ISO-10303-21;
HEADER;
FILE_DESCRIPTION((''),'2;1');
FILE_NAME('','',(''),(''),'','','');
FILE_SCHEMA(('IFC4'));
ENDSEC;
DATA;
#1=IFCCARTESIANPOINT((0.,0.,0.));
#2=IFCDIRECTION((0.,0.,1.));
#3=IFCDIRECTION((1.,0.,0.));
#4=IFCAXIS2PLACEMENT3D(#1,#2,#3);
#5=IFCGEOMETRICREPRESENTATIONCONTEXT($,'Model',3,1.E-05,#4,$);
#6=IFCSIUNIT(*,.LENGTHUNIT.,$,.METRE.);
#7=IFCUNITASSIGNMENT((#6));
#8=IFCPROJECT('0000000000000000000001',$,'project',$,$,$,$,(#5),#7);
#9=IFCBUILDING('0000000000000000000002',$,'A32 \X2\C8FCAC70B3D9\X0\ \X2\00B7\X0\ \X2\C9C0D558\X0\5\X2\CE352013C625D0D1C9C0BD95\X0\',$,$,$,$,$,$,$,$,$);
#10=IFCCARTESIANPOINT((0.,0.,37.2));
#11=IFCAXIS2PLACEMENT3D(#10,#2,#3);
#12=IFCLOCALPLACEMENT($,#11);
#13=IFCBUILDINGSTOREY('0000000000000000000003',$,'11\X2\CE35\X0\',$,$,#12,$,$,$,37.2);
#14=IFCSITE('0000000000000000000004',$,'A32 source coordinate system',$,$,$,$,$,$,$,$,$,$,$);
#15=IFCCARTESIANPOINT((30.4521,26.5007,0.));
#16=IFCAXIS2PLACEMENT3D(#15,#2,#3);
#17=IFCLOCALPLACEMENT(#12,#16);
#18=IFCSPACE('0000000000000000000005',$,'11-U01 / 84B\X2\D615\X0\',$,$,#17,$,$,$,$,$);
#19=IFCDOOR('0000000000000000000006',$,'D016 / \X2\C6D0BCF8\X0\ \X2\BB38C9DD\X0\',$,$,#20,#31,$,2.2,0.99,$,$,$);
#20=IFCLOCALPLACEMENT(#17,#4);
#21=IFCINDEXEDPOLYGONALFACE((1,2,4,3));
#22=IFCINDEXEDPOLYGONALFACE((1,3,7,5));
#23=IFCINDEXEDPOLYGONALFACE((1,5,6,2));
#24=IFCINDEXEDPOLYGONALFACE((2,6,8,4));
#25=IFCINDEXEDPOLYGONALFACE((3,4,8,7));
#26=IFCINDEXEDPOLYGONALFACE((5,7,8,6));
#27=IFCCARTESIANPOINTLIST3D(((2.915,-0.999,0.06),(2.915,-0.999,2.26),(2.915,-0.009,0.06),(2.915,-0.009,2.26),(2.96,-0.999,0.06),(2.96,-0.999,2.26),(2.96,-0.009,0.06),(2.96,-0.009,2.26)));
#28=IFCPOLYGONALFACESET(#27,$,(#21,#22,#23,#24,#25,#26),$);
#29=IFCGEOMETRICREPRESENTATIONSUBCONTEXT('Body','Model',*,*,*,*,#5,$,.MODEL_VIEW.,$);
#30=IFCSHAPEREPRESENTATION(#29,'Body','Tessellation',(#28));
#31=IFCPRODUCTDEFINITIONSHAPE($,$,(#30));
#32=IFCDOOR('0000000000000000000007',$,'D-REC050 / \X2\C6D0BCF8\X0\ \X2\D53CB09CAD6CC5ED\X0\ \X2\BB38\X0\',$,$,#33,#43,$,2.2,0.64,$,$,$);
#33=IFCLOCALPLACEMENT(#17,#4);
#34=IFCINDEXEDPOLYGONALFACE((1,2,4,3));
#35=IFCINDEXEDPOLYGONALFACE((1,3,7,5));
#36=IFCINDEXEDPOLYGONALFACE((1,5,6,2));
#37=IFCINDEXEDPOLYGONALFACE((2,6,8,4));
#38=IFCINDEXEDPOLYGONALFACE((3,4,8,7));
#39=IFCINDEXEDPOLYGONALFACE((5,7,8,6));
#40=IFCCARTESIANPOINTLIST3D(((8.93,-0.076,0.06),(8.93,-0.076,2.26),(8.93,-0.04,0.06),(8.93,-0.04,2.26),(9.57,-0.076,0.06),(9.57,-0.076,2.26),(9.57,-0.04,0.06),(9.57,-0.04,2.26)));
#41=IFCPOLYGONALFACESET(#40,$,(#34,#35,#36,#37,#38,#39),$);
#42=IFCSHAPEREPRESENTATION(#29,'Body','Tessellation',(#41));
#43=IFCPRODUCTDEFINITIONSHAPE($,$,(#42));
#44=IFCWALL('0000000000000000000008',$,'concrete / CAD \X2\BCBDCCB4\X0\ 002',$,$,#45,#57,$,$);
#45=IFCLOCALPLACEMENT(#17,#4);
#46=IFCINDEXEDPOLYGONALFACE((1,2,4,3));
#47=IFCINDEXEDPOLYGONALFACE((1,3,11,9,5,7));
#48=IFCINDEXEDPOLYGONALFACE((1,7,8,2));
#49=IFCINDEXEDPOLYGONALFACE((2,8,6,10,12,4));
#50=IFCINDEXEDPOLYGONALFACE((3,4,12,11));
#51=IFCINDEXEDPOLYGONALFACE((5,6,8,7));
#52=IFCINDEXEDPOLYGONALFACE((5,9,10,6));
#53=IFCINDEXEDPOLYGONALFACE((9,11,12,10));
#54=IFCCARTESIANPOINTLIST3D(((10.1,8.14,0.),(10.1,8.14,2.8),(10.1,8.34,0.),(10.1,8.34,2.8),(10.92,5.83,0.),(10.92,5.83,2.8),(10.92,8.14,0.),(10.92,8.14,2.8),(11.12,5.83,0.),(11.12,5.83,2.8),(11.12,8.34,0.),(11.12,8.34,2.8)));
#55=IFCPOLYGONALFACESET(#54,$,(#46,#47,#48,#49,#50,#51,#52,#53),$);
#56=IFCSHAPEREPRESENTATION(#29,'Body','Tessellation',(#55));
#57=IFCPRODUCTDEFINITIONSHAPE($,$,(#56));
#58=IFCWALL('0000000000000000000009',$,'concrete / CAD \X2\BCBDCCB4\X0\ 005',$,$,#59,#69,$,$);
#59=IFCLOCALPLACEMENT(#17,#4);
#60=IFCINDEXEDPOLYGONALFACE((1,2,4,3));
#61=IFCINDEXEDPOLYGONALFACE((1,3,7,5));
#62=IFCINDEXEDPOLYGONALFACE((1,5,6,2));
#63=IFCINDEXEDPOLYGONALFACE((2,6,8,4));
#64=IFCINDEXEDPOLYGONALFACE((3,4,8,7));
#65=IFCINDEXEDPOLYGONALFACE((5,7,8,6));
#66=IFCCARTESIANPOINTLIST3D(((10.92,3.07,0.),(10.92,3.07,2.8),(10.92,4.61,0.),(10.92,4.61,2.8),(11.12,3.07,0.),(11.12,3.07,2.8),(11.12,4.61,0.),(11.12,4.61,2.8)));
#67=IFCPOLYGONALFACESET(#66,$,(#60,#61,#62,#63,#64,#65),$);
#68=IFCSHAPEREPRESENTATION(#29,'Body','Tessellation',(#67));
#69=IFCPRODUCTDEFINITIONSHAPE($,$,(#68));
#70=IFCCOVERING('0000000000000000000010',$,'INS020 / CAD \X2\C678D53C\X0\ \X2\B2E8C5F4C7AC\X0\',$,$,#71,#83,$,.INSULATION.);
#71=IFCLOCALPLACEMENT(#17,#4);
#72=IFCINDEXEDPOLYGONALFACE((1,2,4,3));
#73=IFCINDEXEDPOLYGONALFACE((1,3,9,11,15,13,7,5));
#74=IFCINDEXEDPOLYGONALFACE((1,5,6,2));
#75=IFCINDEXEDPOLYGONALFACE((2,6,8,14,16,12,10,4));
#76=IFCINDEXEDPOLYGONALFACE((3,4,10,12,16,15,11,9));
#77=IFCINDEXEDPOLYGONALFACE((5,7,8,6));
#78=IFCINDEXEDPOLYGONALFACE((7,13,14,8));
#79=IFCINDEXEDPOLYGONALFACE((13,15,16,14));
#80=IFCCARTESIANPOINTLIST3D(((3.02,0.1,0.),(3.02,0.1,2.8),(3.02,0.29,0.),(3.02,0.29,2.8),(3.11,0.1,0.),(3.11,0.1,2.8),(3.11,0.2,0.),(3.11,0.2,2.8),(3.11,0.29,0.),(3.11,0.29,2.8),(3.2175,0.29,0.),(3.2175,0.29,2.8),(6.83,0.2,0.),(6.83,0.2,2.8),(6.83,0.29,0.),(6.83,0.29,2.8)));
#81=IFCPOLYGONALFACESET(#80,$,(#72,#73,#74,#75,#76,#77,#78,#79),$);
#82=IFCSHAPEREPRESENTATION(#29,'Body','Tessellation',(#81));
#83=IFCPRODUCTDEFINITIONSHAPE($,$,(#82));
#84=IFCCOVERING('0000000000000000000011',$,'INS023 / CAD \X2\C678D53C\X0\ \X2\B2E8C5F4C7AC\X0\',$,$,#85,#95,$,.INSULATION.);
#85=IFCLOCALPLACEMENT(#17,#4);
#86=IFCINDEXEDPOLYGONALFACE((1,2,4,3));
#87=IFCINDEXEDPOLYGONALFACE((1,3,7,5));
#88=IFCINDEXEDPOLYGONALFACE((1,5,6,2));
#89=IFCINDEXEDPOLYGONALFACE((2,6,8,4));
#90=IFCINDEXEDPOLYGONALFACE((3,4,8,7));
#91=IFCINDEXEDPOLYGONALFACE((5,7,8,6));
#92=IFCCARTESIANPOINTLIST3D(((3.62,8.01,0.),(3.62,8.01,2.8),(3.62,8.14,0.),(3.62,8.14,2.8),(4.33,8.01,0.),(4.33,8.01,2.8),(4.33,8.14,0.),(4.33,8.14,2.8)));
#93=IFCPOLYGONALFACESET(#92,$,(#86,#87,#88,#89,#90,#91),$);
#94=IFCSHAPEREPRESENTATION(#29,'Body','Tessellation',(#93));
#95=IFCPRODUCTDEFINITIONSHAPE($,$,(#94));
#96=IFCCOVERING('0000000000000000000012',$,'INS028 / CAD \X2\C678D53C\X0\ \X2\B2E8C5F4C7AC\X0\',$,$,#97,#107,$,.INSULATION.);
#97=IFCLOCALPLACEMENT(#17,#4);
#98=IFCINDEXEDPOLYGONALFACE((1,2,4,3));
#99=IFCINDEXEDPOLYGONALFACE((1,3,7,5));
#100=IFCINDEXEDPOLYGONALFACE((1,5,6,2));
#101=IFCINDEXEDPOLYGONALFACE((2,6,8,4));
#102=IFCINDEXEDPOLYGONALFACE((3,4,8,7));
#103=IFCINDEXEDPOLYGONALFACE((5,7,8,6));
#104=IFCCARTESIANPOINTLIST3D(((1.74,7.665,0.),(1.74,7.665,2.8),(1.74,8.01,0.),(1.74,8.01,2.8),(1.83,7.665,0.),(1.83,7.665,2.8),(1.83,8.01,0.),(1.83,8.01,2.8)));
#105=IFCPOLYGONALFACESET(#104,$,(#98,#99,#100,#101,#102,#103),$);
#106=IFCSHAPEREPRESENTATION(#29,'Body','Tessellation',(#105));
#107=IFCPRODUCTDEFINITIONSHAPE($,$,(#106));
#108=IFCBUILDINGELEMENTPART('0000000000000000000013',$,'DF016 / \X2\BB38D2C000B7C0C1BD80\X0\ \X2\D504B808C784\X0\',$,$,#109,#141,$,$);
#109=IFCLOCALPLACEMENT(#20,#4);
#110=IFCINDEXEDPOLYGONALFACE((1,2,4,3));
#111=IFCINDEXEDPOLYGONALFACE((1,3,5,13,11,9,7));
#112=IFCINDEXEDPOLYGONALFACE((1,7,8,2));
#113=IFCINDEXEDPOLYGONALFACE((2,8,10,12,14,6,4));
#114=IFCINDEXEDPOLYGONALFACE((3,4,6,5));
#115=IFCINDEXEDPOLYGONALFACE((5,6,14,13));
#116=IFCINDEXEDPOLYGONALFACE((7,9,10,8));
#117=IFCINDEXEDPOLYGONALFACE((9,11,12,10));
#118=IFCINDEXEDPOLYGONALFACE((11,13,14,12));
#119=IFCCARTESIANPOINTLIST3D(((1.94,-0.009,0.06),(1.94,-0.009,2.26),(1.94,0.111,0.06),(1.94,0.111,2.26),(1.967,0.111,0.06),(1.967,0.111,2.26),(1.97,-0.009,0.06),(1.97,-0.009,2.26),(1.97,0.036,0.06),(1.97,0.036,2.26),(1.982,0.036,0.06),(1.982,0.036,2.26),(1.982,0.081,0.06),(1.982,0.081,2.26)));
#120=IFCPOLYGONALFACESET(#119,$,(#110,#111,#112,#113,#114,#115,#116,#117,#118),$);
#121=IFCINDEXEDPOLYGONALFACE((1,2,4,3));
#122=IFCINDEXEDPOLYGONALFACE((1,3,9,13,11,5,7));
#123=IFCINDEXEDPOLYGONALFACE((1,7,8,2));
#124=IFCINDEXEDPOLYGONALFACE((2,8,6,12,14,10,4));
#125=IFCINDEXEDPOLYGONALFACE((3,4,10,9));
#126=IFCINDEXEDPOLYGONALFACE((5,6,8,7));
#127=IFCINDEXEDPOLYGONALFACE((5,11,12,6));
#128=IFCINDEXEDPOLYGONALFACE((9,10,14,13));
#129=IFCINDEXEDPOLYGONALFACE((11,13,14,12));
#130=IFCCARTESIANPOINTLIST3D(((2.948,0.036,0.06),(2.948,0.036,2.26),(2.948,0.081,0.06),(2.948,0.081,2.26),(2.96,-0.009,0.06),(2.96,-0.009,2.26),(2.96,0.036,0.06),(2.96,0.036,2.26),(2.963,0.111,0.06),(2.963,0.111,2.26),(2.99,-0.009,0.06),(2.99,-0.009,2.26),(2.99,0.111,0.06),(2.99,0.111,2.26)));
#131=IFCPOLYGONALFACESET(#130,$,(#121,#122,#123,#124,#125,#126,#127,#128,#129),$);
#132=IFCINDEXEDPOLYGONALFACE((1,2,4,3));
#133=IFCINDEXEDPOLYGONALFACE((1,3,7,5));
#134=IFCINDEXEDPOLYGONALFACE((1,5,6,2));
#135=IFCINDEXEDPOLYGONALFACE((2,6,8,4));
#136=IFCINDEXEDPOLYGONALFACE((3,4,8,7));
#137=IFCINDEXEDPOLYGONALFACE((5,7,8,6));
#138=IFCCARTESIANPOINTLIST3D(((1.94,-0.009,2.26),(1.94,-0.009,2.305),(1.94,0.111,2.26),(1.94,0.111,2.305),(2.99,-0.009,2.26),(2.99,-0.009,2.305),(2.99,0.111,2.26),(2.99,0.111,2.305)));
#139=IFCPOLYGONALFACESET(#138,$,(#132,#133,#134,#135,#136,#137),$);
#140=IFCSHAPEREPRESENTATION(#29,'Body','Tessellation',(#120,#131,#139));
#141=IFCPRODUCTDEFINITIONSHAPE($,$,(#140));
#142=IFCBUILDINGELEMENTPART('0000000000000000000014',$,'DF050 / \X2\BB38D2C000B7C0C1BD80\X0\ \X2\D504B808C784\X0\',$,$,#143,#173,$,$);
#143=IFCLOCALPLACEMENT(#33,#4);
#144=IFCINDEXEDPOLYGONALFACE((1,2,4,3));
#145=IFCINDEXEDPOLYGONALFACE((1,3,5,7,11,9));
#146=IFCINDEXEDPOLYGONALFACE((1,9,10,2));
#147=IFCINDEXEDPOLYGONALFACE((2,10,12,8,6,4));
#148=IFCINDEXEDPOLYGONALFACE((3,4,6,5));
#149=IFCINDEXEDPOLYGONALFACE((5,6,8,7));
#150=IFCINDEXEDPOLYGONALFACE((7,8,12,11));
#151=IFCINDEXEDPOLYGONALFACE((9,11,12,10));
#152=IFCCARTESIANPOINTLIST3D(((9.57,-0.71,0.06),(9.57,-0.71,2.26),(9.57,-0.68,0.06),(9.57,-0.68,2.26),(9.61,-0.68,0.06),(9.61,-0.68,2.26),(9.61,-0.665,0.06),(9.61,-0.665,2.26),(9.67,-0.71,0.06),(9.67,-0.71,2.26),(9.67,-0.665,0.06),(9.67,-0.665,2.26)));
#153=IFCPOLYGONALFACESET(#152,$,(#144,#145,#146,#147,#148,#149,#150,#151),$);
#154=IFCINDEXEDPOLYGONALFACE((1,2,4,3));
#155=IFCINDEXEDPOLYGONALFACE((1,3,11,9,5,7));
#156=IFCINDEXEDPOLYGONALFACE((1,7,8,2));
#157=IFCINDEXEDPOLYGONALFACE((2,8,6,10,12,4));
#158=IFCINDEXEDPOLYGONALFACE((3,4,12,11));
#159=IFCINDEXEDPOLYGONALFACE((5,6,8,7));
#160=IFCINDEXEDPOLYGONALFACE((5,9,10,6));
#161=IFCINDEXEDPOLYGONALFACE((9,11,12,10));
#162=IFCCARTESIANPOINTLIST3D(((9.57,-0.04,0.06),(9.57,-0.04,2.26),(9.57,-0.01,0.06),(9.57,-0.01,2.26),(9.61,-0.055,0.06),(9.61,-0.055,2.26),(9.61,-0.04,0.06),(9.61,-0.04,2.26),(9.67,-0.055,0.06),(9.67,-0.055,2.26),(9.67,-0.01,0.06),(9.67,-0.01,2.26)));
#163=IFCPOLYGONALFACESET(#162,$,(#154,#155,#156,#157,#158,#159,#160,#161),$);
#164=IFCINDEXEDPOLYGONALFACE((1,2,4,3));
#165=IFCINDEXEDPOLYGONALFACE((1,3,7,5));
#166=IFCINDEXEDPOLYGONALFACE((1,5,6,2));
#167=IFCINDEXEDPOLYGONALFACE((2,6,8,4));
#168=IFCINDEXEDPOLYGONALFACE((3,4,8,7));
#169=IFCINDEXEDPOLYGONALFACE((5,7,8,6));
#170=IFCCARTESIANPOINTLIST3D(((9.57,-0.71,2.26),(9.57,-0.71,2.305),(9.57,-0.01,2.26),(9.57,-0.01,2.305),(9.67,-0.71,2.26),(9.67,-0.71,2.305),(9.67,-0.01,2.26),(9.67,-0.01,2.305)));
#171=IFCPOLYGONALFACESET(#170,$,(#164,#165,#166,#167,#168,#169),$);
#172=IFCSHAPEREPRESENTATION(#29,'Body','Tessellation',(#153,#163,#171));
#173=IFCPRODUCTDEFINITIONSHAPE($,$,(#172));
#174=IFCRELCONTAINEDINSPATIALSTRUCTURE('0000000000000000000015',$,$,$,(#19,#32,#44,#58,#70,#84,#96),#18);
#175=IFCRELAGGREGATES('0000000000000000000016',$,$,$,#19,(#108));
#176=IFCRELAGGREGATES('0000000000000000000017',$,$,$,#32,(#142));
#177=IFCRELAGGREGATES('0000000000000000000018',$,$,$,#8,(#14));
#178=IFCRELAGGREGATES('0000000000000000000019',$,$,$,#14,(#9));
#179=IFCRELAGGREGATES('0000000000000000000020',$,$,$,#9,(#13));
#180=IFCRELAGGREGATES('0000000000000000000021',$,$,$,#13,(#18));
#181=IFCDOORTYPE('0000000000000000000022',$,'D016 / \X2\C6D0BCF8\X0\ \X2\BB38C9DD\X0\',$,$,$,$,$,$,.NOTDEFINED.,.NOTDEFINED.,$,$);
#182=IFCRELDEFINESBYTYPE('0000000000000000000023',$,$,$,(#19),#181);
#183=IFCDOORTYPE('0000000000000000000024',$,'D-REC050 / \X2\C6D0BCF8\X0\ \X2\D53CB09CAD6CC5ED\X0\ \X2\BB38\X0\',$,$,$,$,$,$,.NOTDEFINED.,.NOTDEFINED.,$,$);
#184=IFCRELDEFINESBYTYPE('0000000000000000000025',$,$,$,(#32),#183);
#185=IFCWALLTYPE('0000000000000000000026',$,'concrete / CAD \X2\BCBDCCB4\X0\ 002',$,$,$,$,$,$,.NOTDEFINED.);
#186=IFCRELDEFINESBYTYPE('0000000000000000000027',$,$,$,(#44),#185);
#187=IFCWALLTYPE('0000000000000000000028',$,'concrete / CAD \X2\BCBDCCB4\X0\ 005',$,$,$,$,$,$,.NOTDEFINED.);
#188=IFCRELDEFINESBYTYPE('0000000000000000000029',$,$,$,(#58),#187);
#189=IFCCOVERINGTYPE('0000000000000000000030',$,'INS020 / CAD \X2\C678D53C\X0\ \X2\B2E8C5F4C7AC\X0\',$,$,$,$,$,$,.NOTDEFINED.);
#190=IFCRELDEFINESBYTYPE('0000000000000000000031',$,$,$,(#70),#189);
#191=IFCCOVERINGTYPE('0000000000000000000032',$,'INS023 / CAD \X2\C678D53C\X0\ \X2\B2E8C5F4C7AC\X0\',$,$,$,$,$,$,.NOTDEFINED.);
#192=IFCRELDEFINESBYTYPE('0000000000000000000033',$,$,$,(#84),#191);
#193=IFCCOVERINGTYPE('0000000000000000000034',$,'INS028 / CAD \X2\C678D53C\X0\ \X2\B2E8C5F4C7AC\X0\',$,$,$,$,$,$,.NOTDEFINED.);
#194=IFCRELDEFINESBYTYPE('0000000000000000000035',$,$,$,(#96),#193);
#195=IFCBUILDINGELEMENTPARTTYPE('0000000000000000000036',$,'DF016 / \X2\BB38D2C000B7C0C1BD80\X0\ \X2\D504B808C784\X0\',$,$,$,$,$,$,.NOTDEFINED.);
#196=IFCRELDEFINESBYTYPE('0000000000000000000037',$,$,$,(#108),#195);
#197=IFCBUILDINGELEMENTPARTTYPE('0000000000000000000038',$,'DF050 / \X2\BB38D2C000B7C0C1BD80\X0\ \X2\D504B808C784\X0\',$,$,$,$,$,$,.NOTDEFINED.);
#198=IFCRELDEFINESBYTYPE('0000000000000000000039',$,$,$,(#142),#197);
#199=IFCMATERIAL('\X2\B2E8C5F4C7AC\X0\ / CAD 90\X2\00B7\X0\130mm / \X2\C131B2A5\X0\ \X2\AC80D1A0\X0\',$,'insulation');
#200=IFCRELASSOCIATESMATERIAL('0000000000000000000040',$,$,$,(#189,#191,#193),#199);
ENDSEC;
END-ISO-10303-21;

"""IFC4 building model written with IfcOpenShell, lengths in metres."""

from ifc_helpers import new_model, si_unit, frame, origin, origin_with_axes, place, context, subcontext, project, spatial, polyline, outline, extrude, source, transform, mapped, material, type_object, type_shapes, element, aggregate, save


model = new_model("IFC4")

# Units and contexts
model_context = context("Model", 3, precision=1e-05, world=origin_with_axes())
body_context = subcontext(model_context, "Body", "Model", "MODEL_VIEW")
ifc_project = project(units=[si_unit("LENGTHUNIT", "METRE")], contexts=[model_context])

# Site, building, storey, space
storey_placement = place(None, frame((0.0, 0.0, 37.2), z_axis=(0.0, 0.0, 1.0), x_axis=(1.0, 0.0, 0.0)))
space_placement = place(storey_placement, frame((30.4521, 26.5007, 0.0), z_axis=(0.0, 0.0, 1.0), x_axis=(1.0, 0.0, 0.0)))
site = spatial("IfcSite", under=ifc_project, Name="A32 source coordinate system")
building = spatial("IfcBuilding", under=site, Name="A32 주거동 · 지하5층–옥탑지붕")
storey = spatial("IfcBuildingStorey", under=building, at=storey_placement, Name="11층", Elevation=37.2)
space = spatial("IfcSpace", under=storey, at=space_placement, Name="11-U01 / 84B형")

# Doors
door_type_1 = type_object("IfcDoorType", Name="D016 / 원본 문짝", OperationType="NOTDEFINED", PredefinedType="NOTDEFINED")
shared_shape_1 = source(origin(), body_context, "Body", "SweptSolid", [
    extrude(outline(polyline([(2.96, -0.009), (2.96, -0.999), (2.915, -0.999), (2.915, -0.009), (2.96, -0.009)])), frame((0.0, 0.0, 0.06)), (0.0, 0.0, 1.0), 2.2),
])
type_shapes(door_type_1, [shared_shape_1])
door_1_placement = place(space_placement, origin_with_axes())
door_1 = element("IfcDoor", 1, at=door_1_placement, inside=space, type_object=door_type_1, Name="D016 / 원본 문짝", OverallHeight=2.2, OverallWidth=0.99, context=body_context, shape_type="MappedRepresentation", body=[
    mapped(shared_shape_1, transform((0.0, 0.0, 0.0), scale=1.0)),
])
door_type_2 = type_object("IfcDoorType", Name="D-REC050 / 원본 피난구역 문", OperationType="NOTDEFINED", PredefinedType="NOTDEFINED")
shared_shape_2 = source(origin(), body_context, "Body", "SweptSolid", [
    extrude(outline(polyline([(9.57, -0.04), (9.57, -0.076), (8.93, -0.076), (8.93, -0.04), (9.57, -0.04)])), frame((0.0, 0.0, 0.06)), (0.0, 0.0, 1.0), 2.2),
])
type_shapes(door_type_2, [shared_shape_2])
door_2_placement = place(space_placement, origin_with_axes())
door_2 = element("IfcDoor", 2, at=door_2_placement, inside=space, type_object=door_type_2, Name="D-REC050 / 원본 피난구역 문", OverallHeight=2.2, OverallWidth=0.64, context=body_context, shape_type="MappedRepresentation", body=[
    mapped(shared_shape_2, transform((0.0, 0.0, 0.0), scale=1.0)),
])

# Walls
wall_type_1 = type_object("IfcWallType", Name="concrete / CAD 벽체 002", PredefinedType="NOTDEFINED")
shared_shape_3 = source(origin(), body_context, "Body", "SweptSolid", [
    extrude(outline(polyline([(11.12, 5.83), (10.92, 5.83), (10.92, 8.14), (10.1, 8.14), (10.1, 8.34), (11.12, 8.34), (11.12, 5.83)])), origin(), (0.0, 0.0, 1.0), 2.8),
])
type_shapes(wall_type_1, [shared_shape_3])
wall_1_placement = place(space_placement, origin_with_axes())
element("IfcWall", 3, at=wall_1_placement, inside=space, type_object=wall_type_1, Name="concrete / CAD 벽체 002", context=body_context, shape_type="MappedRepresentation", body=[
    mapped(shared_shape_3, transform((0.0, 0.0, 0.0), scale=1.0)),
])
wall_type_2 = type_object("IfcWallType", Name="concrete / CAD 벽체 005", PredefinedType="NOTDEFINED")
shared_shape_4 = source(origin(), body_context, "Body", "SweptSolid", [
    extrude(outline(polyline([(11.12, 3.07), (10.92, 3.07), (10.92, 4.61), (11.12, 4.61), (11.12, 3.07)])), origin(), (0.0, 0.0, 1.0), 2.8),
])
type_shapes(wall_type_2, [shared_shape_4])
wall_2_placement = place(space_placement, origin_with_axes())
element("IfcWall", 4, at=wall_2_placement, inside=space, type_object=wall_type_2, Name="concrete / CAD 벽체 005", context=body_context, shape_type="MappedRepresentation", body=[
    mapped(shared_shape_4, transform((0.0, 0.0, 0.0), scale=1.0)),
])

# Coverings
ifc_material = material(Name="단열재 / CAD 90·130mm / 성능 검토", Category="insulation")
covering_type_1 = type_object("IfcCoveringType", Name="INS020 / CAD 외피 단열재", PredefinedType="NOTDEFINED", material=ifc_material)
shared_shape_5 = source(origin(), body_context, "Body", "SweptSolid", [
    extrude(outline(polyline([(3.11, 0.2), (3.11, 0.1), (3.02, 0.1), (3.02, 0.29), (3.11, 0.29), (3.2175, 0.29), (6.83, 0.29), (6.83, 0.2), (3.11, 0.2)])), origin(), (0.0, 0.0, 1.0), 2.8),
])
type_shapes(covering_type_1, [shared_shape_5])
covering_1_placement = place(space_placement, origin_with_axes())
element("IfcCovering", 5, at=covering_1_placement, inside=space, type_object=covering_type_1, Name="INS020 / CAD 외피 단열재", PredefinedType="INSULATION", context=body_context, shape_type="MappedRepresentation", body=[
    mapped(shared_shape_5, transform((0.0, 0.0, 0.0), scale=1.0)),
])
covering_type_2 = type_object("IfcCoveringType", Name="INS023 / CAD 외피 단열재", PredefinedType="NOTDEFINED", material=ifc_material)
shared_shape_6 = source(origin(), body_context, "Body", "SweptSolid", [
    extrude(outline(polyline([(4.33, 8.01), (3.62, 8.01), (3.62, 8.14), (4.33, 8.14), (4.33, 8.01)])), origin(), (0.0, 0.0, 1.0), 2.8),
])
type_shapes(covering_type_2, [shared_shape_6])
covering_2_placement = place(space_placement, origin_with_axes())
element("IfcCovering", 6, at=covering_2_placement, inside=space, type_object=covering_type_2, Name="INS023 / CAD 외피 단열재", PredefinedType="INSULATION", context=body_context, shape_type="MappedRepresentation", body=[
    mapped(shared_shape_6, transform((0.0, 0.0, 0.0), scale=1.0)),
])
covering_type_3 = type_object("IfcCoveringType", Name="INS028 / CAD 외피 단열재", PredefinedType="NOTDEFINED", material=ifc_material)
shared_shape_7 = source(origin(), body_context, "Body", "SweptSolid", [
    extrude(outline(polyline([(1.74, 8.01), (1.83, 8.01), (1.83, 7.665), (1.74, 7.665), (1.74, 8.01)])), origin(), (0.0, 0.0, 1.0), 2.8),
])
type_shapes(covering_type_3, [shared_shape_7])
covering_3_placement = place(space_placement, origin_with_axes())
element("IfcCovering", 7, at=covering_3_placement, inside=space, type_object=covering_type_3, Name="INS028 / CAD 외피 단열재", PredefinedType="INSULATION", context=body_context, shape_type="MappedRepresentation", body=[
    mapped(shared_shape_7, transform((0.0, 0.0, 0.0), scale=1.0)),
])

# Building element parts
building_element_part_type_1 = type_object("IfcBuildingElementPartType", Name="DF016 / 문틀·상부 프레임", PredefinedType="NOTDEFINED")
shared_shape_8 = source(origin(), body_context, "Body", "SweptSolid", [
    extrude(outline(polyline([(1.94, 0.111), (1.967, 0.111), (1.982, 0.081), (1.982, 0.036), (1.97, 0.036), (1.97, -0.009), (1.94, -0.009), (1.94, 0.111)])), frame((0.0, 0.0, 0.06)), (0.0, 0.0, 1.0), 2.2),
    extrude(outline(polyline([(2.96, -0.009), (2.96, 0.036), (2.948, 0.036), (2.948, 0.081), (2.963, 0.111), (2.99, 0.111), (2.99, -0.009), (2.96, -0.009)])), frame((0.0, 0.0, 0.06)), (0.0, 0.0, 1.0), 2.2),
    extrude(outline(polyline([(1.94, -0.009), (1.94, 0.111), (2.99, 0.111), (2.99, -0.009), (1.94, -0.009)])), frame((0.0, 0.0, 2.26)), (0.0, 0.0, 1.0), 0.045),
])
type_shapes(building_element_part_type_1, [shared_shape_8])
building_element_part_1_placement = place(door_1_placement, origin_with_axes())
building_element_part_1 = element("IfcBuildingElementPart", 8, at=building_element_part_1_placement, type_object=building_element_part_type_1, Name="DF016 / 문틀·상부 프레임", context=body_context, shape_type="MappedRepresentation", body=[
    mapped(shared_shape_8, transform((0.0, 0.0, 0.0), scale=1.0)),
])
aggregate(door_1, [building_element_part_1])
building_element_part_type_2 = type_object("IfcBuildingElementPartType", Name="DF050 / 문틀·상부 프레임", PredefinedType="NOTDEFINED")
shared_shape_9 = source(origin(), body_context, "Body", "SweptSolid", [
    extrude(outline(polyline([(9.57, -0.68), (9.61, -0.68), (9.61, -0.665), (9.67, -0.665), (9.67, -0.71), (9.57, -0.71), (9.57, -0.68)])), frame((0.0, 0.0, 0.06)), (0.0, 0.0, 1.0), 2.2),
    extrude(outline(polyline([(9.67, -0.01), (9.67, -0.055), (9.61, -0.055), (9.61, -0.04), (9.57, -0.04), (9.57, -0.01), (9.67, -0.01)])), frame((0.0, 0.0, 0.06)), (0.0, 0.0, 1.0), 2.2),
    extrude(outline(polyline([(9.57, -0.71), (9.57, -0.01), (9.67, -0.01), (9.67, -0.71), (9.57, -0.71)])), frame((0.0, 0.0, 2.26)), (0.0, 0.0, 1.0), 0.045),
])
type_shapes(building_element_part_type_2, [shared_shape_9])
building_element_part_2_placement = place(door_2_placement, origin_with_axes())
building_element_part_2 = element("IfcBuildingElementPart", 9, at=building_element_part_2_placement, type_object=building_element_part_type_2, Name="DF050 / 문틀·상부 프레임", context=body_context, shape_type="MappedRepresentation", body=[
    mapped(shared_shape_9, transform((0.0, 0.0, 0.0), scale=1.0)),
])
aggregate(door_2, [building_element_part_2])

save(model, "model.ifc")
